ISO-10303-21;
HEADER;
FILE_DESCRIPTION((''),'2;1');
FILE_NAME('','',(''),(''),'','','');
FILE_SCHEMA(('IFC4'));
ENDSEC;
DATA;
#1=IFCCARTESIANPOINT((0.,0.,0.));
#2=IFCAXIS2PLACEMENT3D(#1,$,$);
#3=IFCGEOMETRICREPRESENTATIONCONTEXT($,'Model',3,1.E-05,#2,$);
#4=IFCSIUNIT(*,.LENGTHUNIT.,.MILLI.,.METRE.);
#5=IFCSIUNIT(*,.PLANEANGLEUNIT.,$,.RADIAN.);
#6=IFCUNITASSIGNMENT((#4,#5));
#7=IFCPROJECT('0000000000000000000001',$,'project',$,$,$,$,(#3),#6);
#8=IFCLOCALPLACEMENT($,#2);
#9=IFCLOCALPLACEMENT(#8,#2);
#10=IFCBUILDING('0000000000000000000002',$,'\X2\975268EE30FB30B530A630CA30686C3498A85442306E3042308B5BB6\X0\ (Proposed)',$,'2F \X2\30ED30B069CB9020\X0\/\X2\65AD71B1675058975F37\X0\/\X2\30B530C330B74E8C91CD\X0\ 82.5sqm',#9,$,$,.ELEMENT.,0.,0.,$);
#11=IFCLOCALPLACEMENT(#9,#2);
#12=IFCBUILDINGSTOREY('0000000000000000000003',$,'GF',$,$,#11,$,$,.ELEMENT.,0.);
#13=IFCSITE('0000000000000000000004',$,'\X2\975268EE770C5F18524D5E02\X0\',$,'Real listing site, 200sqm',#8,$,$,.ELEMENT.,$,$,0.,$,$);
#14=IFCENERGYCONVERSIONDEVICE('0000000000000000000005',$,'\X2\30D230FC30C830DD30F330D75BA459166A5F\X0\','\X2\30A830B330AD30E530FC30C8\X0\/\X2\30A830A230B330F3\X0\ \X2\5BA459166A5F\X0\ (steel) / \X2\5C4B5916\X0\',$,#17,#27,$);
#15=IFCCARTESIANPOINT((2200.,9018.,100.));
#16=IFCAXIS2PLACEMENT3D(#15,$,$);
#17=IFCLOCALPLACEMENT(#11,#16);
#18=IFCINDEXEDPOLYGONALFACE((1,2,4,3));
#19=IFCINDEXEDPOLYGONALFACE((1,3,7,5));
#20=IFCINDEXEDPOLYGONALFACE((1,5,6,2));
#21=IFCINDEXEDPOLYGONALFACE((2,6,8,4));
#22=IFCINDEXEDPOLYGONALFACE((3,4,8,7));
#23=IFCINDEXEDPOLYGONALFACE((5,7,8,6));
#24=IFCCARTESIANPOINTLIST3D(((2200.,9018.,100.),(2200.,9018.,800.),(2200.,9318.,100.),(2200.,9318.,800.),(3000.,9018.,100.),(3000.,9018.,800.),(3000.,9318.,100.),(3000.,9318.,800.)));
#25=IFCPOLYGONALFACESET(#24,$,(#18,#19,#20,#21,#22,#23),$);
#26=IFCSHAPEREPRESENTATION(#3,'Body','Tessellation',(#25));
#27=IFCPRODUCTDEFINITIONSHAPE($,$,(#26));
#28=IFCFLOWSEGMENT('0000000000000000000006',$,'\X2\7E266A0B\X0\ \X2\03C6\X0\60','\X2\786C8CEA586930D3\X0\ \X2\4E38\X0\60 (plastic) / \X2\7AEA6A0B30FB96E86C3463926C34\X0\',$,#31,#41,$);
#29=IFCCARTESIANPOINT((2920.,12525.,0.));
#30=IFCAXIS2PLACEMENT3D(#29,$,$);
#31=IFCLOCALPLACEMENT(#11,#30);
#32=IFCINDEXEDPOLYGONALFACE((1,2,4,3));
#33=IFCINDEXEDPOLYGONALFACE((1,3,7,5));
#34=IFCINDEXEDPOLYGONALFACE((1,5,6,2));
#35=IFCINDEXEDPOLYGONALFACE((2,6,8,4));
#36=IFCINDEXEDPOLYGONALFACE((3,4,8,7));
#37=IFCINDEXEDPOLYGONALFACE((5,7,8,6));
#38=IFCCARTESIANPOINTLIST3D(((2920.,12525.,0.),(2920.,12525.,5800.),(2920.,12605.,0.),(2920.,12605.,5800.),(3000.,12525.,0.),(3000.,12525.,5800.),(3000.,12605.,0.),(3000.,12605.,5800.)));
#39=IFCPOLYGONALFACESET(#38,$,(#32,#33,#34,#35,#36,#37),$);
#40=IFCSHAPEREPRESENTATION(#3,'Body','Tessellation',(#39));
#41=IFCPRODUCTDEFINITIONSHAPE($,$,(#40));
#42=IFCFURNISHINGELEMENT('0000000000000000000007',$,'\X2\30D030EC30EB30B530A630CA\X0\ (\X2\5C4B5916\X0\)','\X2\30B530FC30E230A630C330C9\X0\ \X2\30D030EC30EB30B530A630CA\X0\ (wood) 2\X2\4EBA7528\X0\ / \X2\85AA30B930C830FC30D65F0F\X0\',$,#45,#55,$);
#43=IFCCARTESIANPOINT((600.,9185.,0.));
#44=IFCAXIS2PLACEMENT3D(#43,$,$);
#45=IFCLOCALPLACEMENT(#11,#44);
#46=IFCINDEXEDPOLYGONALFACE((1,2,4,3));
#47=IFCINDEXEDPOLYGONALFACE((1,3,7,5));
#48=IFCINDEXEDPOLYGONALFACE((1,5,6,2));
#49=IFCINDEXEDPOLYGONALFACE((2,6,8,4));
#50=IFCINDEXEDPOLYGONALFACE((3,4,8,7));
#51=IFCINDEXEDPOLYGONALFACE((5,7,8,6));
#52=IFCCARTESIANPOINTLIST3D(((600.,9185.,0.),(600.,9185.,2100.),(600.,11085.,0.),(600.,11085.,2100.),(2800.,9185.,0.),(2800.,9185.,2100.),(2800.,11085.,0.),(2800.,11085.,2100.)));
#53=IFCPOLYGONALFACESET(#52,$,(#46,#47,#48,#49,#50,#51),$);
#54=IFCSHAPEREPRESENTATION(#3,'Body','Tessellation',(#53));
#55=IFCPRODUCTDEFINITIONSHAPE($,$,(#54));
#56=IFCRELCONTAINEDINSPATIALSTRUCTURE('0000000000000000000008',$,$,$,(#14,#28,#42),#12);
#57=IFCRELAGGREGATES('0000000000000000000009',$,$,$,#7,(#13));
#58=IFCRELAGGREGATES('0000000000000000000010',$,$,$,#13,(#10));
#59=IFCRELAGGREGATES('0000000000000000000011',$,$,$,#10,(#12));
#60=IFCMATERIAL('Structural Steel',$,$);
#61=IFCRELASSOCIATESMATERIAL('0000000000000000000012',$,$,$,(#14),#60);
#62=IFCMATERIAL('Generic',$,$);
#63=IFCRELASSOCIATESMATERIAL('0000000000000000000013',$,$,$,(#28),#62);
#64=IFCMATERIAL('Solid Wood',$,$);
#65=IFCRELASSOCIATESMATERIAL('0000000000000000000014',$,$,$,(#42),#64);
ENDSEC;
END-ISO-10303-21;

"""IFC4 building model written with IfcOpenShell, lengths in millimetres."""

from ifc_helpers import new_model, si_unit, frame, frame_2d, origin, place, context, project, spatial, rectangle, extrude, material, element, save


model = new_model("IFC4")

# Units and contexts
model_context = context("Model", 3, precision=1e-05, world=origin())
ifc_project = project(units=[si_unit("LENGTHUNIT", "METRE", prefix="MILLI"), si_unit("PLANEANGLEUNIT", "RADIAN")], contexts=[model_context])

# Site, building, storey
site_placement = place(None, origin())
site = spatial("IfcSite", under=ifc_project, at=site_placement, Name="青森県弘前市", ObjectType="Real listing site, 200sqm", CompositionType="ELEMENT", RefElevation=0.0)
building_placement = place(site_placement, origin())
building = spatial("IfcBuilding", under=site, at=building_placement, Name="青森・サウナと水風呂のある家 (Proposed)", ObjectType="2F ログ構造/断熱材増強/サッシ二重 82.5sqm", CompositionType="ELEMENT", ElevationOfRefHeight=0.0, ElevationOfTerrain=0.0)
storey_placement = place(building_placement, origin())
storey = spatial("IfcBuildingStorey", under=building, at=storey_placement, Name="GF", CompositionType="ELEMENT", Elevation=0.0)

# Shared definitions
ifc_material_1 = material(Name="Solid Wood")

# Shared definitions
ifc_material_2 = material(Name="Generic")

# Energy conversion device
ifc_material_3 = material(Name="Structural Steel")
energy_conversion_device_placement = place(storey_placement, frame((2200.0, 9018.0, 100.0)))
element("IfcEnergyConversionDevice", 1, at=energy_conversion_device_placement, inside=storey, material=ifc_material_3, Name="ヒートポンプ室外機", Description="エコキュート/エアコン 室外機 (steel) / 屋外", context=model_context, shape_type="SweptSolid", body=[
    extrude(rectangle(XDim=800.0, YDim=300.0, at=frame_2d((400.0, 150.0))), frame((2200.0, 9018.0, 100.0)), (0.0, 0.0, 1.0), 700.0),
])

# Flow segment
flow_segment_placement = place(storey_placement, frame((2920.0, 12525.0, 0.0)))
element("IfcFlowSegment", 2, at=flow_segment_placement, inside=storey, material=ifc_material_2, Name="縦樋 φ60", Description="硬質塩ビ 丸60 (plastic) / 竪樋・雨水排水", context=model_context, shape_type="SweptSolid", body=[
    extrude(rectangle(XDim=80.0, YDim=80.0, at=frame_2d((40.0, 40.0))), frame((2920.0, 12525.0, 0.0)), (0.0, 0.0, 1.0), 5800.0),
])

# Furnishing element
furnishing_placement = place(storey_placement, frame((600.0, 9185.0, 0.0)))
element("IfcFurnishingElement", 3, at=furnishing_placement, inside=storey, material=ifc_material_1, Name="バレルサウナ (屋外)", Description="サーモウッド バレルサウナ (wood) 2人用 / 薪ストーブ式", context=model_context, shape_type="SweptSolid", body=[
    extrude(rectangle(XDim=2200.0, YDim=1900.0, at=frame_2d((1100.0, 950.0))), frame((600.0, 9185.0, 0.0)), (0.0, 0.0, 1.0), 2100.0),
])

save(model, "model.ifc")
